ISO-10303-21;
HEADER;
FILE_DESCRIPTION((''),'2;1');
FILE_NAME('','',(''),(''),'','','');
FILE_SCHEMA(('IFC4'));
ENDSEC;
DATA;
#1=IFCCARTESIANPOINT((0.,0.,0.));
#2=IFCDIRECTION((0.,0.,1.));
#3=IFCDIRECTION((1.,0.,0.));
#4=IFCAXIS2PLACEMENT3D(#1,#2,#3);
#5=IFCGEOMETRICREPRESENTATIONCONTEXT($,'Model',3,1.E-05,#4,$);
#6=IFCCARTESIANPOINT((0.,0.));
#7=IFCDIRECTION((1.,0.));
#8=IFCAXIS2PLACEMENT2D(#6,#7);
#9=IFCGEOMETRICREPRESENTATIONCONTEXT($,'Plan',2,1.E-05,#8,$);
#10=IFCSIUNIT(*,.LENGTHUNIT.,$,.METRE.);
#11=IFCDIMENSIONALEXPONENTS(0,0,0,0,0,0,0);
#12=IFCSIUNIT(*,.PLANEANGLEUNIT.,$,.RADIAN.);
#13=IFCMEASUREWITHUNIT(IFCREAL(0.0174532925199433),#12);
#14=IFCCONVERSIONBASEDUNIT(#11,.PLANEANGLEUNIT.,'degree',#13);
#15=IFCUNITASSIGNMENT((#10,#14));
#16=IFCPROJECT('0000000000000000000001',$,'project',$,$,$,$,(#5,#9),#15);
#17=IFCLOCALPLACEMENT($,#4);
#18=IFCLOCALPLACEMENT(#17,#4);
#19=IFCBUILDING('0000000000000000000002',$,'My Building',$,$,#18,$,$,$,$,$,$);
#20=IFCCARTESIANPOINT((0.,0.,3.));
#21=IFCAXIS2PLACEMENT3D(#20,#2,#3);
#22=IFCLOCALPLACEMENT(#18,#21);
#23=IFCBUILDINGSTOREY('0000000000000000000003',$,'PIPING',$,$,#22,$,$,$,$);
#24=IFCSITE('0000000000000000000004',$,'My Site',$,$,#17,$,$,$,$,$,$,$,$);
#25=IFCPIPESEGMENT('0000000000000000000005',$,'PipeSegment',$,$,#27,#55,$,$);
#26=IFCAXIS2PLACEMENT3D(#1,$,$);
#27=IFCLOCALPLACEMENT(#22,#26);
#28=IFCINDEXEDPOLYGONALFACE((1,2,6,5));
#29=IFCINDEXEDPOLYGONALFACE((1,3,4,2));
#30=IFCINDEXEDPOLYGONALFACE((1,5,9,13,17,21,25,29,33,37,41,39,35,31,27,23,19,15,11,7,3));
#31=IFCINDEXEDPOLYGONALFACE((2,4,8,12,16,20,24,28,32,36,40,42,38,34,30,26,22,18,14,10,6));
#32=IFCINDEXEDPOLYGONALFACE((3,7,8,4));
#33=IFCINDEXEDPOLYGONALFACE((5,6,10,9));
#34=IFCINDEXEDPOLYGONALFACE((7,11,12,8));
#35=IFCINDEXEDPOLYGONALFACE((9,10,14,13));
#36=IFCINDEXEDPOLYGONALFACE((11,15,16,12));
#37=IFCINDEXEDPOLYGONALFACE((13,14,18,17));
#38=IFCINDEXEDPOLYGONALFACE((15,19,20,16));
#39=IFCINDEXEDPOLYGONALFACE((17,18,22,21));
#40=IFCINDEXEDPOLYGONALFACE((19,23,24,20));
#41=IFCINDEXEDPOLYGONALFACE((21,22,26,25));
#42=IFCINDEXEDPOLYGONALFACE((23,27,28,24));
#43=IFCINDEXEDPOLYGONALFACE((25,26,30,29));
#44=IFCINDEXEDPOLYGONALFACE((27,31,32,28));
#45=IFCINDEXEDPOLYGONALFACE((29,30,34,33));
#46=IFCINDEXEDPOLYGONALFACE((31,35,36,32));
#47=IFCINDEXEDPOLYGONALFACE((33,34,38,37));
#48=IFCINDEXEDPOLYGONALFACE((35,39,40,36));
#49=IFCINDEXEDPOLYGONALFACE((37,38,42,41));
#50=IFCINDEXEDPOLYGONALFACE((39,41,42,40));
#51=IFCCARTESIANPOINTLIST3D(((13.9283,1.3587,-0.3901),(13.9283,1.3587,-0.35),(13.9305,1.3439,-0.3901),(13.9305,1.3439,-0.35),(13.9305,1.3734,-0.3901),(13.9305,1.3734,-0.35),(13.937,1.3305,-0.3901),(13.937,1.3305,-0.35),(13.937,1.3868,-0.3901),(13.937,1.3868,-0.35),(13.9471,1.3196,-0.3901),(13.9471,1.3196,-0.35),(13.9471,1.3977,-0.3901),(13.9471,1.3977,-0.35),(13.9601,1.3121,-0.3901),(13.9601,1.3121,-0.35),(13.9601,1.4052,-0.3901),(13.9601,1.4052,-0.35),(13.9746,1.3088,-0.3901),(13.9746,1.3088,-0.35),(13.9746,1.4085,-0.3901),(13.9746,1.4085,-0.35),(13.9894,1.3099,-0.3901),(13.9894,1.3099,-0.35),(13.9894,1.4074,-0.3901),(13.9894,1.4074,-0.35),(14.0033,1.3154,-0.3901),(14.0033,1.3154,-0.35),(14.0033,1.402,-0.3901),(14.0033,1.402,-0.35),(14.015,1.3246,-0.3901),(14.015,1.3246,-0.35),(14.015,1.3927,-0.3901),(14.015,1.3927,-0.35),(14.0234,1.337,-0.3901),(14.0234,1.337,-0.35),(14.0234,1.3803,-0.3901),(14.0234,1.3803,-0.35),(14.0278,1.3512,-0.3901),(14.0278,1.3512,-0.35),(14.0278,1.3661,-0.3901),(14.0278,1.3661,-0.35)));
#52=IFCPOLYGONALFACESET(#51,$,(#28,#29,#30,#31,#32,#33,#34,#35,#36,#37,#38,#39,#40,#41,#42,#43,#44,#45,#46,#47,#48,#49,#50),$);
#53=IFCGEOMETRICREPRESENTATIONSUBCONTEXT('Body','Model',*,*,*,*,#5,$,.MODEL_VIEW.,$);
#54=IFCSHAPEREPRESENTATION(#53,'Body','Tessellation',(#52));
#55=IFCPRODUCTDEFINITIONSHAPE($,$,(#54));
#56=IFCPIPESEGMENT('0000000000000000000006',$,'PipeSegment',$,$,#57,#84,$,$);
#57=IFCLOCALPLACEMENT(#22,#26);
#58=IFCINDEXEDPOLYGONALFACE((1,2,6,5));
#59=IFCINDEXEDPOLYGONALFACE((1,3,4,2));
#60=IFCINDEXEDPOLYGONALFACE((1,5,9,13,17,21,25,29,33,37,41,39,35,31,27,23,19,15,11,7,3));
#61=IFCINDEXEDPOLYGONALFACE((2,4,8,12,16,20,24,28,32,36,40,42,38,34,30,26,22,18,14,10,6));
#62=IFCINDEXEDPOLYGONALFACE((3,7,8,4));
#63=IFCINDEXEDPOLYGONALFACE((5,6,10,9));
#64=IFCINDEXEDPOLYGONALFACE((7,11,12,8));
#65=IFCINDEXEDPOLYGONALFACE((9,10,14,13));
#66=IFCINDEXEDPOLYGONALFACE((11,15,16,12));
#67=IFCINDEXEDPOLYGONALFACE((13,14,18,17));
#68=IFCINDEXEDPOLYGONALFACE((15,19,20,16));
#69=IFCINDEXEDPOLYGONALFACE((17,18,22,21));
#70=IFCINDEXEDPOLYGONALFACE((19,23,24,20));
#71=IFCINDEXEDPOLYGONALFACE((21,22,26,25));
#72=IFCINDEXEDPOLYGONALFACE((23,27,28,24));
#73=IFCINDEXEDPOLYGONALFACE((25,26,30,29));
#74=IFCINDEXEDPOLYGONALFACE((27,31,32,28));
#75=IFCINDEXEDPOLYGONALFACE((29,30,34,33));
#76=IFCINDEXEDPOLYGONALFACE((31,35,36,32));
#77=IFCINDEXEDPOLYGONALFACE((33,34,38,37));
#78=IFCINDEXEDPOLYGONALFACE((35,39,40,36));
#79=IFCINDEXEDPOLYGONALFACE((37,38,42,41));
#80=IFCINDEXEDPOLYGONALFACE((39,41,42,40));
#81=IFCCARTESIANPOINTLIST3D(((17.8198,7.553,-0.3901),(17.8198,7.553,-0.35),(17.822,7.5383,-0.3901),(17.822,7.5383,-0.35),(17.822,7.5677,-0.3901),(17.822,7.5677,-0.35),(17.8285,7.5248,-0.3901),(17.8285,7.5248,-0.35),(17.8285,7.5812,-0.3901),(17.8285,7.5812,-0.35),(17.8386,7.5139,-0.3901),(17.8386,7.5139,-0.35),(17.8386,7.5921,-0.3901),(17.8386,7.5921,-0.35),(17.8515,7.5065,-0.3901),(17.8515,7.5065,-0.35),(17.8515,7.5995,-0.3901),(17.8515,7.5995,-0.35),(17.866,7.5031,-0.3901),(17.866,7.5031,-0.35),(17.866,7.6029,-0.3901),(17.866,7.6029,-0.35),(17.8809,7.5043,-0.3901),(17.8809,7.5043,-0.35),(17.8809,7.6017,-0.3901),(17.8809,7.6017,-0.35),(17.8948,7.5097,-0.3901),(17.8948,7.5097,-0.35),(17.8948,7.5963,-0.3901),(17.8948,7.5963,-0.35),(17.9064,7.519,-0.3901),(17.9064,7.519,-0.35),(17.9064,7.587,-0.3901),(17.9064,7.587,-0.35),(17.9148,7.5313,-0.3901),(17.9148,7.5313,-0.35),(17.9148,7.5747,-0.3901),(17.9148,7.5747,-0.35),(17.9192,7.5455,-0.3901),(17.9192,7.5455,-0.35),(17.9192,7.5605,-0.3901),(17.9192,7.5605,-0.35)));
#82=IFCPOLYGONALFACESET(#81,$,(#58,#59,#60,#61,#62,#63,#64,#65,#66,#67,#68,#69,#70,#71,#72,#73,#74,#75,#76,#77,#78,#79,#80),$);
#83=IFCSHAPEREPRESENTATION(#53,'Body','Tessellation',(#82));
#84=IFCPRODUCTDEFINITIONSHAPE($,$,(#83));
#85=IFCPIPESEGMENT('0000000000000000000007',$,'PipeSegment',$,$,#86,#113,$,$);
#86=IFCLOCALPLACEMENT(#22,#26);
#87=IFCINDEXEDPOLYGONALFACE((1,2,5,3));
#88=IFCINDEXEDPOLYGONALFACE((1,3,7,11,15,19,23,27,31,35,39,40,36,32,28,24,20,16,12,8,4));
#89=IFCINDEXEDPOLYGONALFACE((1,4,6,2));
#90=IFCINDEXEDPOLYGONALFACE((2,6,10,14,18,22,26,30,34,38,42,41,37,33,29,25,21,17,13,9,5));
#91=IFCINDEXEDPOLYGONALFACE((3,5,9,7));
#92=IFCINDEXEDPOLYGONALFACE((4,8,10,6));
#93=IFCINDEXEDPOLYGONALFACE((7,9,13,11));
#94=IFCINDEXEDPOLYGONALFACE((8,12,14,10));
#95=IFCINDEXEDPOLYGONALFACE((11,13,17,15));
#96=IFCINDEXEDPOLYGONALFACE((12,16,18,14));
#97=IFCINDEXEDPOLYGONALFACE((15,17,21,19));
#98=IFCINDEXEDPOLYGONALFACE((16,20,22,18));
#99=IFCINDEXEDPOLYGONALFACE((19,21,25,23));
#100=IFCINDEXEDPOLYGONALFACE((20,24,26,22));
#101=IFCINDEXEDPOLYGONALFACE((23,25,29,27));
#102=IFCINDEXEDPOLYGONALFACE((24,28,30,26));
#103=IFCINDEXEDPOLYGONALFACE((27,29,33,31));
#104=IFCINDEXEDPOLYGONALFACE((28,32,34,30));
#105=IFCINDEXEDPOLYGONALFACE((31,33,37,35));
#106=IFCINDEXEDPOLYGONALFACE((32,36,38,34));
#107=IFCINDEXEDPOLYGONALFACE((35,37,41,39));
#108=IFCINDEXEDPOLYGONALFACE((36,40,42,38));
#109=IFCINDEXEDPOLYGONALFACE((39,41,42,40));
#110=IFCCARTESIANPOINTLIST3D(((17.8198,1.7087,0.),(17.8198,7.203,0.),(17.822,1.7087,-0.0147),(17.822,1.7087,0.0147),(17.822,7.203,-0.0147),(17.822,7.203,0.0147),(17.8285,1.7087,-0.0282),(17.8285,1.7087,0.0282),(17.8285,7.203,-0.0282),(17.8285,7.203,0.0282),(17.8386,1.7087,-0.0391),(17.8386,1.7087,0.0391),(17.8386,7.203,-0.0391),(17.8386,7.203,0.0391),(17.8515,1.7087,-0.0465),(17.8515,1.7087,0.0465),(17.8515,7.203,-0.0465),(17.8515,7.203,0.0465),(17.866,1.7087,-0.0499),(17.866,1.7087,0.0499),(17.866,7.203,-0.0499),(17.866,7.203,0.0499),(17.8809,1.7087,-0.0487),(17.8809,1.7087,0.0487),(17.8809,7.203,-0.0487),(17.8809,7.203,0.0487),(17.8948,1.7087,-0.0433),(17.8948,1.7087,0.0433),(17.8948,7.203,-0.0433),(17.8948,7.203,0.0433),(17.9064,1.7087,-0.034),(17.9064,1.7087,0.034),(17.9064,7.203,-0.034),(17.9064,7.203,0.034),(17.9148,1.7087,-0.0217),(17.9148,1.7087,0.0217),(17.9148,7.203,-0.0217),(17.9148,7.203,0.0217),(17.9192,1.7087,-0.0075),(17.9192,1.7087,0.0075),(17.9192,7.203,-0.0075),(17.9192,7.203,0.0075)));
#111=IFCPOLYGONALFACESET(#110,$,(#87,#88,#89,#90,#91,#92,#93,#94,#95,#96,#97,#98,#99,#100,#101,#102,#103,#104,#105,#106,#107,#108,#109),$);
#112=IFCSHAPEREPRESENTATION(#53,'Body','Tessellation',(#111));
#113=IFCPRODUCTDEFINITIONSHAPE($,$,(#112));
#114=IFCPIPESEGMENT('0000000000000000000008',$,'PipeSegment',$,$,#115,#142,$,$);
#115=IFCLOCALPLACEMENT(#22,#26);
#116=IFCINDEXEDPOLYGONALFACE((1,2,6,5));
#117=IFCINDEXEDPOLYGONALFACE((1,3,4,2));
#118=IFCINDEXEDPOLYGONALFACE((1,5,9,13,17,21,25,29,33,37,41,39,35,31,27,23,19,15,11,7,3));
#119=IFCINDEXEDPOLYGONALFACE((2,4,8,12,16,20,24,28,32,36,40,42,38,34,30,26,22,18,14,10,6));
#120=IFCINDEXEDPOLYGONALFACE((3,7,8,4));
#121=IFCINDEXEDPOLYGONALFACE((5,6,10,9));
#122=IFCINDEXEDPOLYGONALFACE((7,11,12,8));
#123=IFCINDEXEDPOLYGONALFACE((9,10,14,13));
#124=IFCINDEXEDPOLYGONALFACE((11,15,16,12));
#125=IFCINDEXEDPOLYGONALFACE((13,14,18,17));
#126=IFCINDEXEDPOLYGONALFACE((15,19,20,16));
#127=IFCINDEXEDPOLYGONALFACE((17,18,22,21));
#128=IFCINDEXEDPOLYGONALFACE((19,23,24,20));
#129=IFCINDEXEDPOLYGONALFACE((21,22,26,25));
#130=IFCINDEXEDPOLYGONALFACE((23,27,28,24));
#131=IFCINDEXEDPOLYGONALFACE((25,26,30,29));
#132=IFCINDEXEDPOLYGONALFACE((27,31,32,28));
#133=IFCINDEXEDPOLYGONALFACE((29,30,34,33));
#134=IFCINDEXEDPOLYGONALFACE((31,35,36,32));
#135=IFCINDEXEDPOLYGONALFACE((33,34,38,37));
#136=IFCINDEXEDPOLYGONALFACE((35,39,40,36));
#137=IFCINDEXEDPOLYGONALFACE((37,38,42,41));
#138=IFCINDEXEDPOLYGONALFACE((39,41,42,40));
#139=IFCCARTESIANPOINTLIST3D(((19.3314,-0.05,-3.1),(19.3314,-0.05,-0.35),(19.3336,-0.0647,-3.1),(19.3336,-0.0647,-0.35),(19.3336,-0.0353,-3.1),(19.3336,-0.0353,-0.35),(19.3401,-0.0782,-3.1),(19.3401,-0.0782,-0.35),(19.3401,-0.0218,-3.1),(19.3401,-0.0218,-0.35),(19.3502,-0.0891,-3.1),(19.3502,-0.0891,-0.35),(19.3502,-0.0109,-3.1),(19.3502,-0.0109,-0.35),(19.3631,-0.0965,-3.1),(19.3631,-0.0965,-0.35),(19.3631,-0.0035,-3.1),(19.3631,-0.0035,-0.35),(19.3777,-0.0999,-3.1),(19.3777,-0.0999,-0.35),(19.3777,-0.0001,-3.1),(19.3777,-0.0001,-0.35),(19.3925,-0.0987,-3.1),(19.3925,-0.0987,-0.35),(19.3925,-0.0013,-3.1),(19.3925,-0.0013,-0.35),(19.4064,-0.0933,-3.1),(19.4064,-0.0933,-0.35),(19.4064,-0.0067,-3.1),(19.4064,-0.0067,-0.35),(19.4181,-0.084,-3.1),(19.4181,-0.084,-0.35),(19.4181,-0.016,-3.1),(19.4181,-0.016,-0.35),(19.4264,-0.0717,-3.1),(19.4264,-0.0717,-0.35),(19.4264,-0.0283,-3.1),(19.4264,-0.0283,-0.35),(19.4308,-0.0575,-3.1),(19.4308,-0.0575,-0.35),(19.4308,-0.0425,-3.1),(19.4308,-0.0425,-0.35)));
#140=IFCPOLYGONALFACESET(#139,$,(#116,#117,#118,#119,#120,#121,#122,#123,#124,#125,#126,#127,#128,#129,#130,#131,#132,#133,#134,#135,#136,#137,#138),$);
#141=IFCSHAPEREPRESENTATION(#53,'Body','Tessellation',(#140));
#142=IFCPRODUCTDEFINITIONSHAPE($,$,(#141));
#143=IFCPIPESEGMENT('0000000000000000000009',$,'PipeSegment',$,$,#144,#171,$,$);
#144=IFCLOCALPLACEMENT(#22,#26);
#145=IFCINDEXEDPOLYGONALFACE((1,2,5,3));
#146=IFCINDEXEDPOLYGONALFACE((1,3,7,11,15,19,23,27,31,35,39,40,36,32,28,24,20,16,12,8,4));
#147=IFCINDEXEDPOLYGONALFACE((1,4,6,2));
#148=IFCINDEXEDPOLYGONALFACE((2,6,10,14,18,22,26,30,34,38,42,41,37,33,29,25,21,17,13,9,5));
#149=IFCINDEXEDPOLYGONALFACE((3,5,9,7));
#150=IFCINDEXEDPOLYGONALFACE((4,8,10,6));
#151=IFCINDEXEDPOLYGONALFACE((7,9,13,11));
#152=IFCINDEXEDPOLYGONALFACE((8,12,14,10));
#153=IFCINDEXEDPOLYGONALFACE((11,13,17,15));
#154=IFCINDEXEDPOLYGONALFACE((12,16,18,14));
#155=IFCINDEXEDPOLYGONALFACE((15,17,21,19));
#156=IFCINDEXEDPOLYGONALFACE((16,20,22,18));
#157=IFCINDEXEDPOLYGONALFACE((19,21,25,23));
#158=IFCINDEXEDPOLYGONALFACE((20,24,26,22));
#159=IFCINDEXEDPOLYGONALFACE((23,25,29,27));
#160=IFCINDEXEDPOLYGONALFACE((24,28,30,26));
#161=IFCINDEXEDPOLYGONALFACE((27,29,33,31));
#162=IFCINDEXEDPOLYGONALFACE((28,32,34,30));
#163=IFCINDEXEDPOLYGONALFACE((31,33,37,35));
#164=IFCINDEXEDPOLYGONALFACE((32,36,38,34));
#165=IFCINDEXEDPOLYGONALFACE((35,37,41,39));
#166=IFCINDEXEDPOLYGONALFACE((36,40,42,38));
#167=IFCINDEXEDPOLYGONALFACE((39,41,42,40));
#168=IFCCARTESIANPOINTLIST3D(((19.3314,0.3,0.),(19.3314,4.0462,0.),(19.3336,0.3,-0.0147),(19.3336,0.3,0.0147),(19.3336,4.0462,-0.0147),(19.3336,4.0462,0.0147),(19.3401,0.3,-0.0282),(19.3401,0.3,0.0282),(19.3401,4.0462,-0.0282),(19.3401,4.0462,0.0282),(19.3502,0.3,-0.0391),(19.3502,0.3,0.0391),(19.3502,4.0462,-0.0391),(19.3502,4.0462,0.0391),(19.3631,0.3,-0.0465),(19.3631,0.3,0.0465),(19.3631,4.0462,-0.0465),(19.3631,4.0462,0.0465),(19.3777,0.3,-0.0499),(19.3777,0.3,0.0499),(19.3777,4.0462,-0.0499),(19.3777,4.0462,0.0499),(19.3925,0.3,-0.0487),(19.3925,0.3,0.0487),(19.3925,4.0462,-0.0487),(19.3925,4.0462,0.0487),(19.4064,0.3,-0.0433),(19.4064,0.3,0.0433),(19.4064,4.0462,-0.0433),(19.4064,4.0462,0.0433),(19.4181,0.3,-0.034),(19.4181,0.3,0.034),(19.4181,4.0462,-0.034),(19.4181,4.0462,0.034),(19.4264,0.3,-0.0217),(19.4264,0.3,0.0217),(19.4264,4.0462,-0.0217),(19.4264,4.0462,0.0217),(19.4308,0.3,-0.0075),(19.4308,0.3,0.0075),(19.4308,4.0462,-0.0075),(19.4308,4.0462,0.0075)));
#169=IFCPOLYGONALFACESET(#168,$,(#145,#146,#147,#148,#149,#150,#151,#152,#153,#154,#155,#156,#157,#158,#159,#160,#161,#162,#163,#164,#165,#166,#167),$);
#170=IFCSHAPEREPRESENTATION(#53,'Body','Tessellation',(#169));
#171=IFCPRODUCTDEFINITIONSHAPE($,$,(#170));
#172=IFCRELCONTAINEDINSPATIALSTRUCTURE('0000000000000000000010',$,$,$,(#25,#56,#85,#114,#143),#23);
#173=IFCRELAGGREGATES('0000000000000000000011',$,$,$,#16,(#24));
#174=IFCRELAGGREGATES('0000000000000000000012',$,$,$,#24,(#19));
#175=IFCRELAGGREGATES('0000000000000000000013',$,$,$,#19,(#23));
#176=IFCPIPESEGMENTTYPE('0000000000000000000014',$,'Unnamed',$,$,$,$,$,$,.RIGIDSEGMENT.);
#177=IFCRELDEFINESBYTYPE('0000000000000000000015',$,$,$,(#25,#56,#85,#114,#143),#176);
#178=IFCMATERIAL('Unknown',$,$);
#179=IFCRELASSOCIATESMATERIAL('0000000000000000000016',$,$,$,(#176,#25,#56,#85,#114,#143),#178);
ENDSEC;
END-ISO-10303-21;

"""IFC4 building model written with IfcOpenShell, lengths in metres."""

from ifc_helpers import new_model, entity, si_unit, converted_unit, frame, origin_with_axes, origin_2d_with_axis, place, context, subcontext, project, spatial, circle, extrude, material, material_profile, profile_set, profile_usage, type_object, element, save


model = new_model("IFC4")

# Units and contexts
model_context = context("Model", 3, precision=1e-05, world=origin_with_axes())
plan_context = context("Plan", 2, precision=1e-05, world=origin_2d_with_axis())
body_context = subcontext(model_context, "Body", "Model", "MODEL_VIEW")
ifc_project = project(units=[si_unit("LENGTHUNIT", "METRE"), converted_unit("PLANEANGLEUNIT", "degree", entity("IfcReal", 0.0174532925199433), si_unit("PLANEANGLEUNIT", "RADIAN"), dimensions=[0, 0, 0, 0, 0, 0, 0])], contexts=[model_context, plan_context])

# Site, building, storey
site_placement = place(None, origin_with_axes())
site = spatial("IfcSite", under=ifc_project, at=site_placement, Name="My Site")
building_placement = place(site_placement, origin_with_axes())
building = spatial("IfcBuilding", under=site, at=building_placement, Name="My Building")
storey_placement = place(building_placement, frame((0.0, 0.0, 3.0), z_axis=(0.0, 0.0, 1.0), x_axis=(1.0, 0.0, 0.0)))
storey = spatial("IfcBuildingStorey", under=building, at=storey_placement, Name="PIPING")

# Pipe segments
ifc_material = material(Name="Unknown")
ifc_material_profile = material_profile(ifc_material, circle(Radius=0.05))
ifc_profile_set = profile_set([ifc_material_profile])
pipe_segment_type = type_object("IfcPipeSegmentType", Name="Unnamed", PredefinedType="RIGIDSEGMENT", material=ifc_profile_set)
ifc_profile_usage_1 = profile_usage(ifc_profile_set, cardinal=5)
pipe_segment_1_placement = place(storey_placement, frame((13.9783, 1.3587, -0.35), z_axis=(0.0, 0.0, -1.0), x_axis=(-1.0, 0.0, 0.0)))
element("IfcPipeSegment", 1, at=pipe_segment_1_placement, inside=storey, type_object=pipe_segment_type, material=ifc_profile_usage_1, Name="PipeSegment", context=body_context, shape_type="SweptSolid", body=[
    extrude(circle(Radius=0.05), origin_with_axes(), (0.0, 0.0, 1.0), 0.0401),
])
ifc_profile_usage_2 = profile_usage(ifc_profile_set, cardinal=5)
pipe_segment_2_placement = place(storey_placement, frame((17.8698, 7.553, -0.35), z_axis=(0.0, 0.0, -1.0), x_axis=(-1.0, 0.0, 0.0)))
element("IfcPipeSegment", 2, at=pipe_segment_2_placement, inside=storey, type_object=pipe_segment_type, material=ifc_profile_usage_2, Name="PipeSegment", context=body_context, shape_type="SweptSolid", body=[
    extrude(circle(Radius=0.05), origin_with_axes(), (0.0, 0.0, 1.0), 0.0401),
])
ifc_profile_usage_3 = profile_usage(ifc_profile_set, cardinal=5)
pipe_segment_3_placement = place(storey_placement, frame((17.8698, 1.7087, 0.0), z_axis=(0.0, 1.0, 0.0), x_axis=(-1.0, 0.0, 0.0)))
element("IfcPipeSegment", 3, at=pipe_segment_3_placement, inside=storey, type_object=pipe_segment_type, material=ifc_profile_usage_3, Name="PipeSegment", context=body_context, shape_type="SweptSolid", body=[
    extrude(circle(Radius=0.05), origin_with_axes(), (0.0, 0.0, 1.0), 5.4943),
])
ifc_profile_usage_4 = profile_usage(ifc_profile_set, cardinal=5)
pipe_segment_4_placement = place(storey_placement, frame((19.3814, -0.05, -0.35), z_axis=(0.0, 0.0, -1.0), x_axis=(-1.0, 0.0, 0.0)))
element("IfcPipeSegment", 4, at=pipe_segment_4_placement, inside=storey, type_object=pipe_segment_type, material=ifc_profile_usage_4, Name="PipeSegment", context=body_context, shape_type="SweptSolid", body=[
    extrude(circle(Radius=0.05), origin_with_axes(), (0.0, 0.0, 1.0), 2.75),
])
ifc_profile_usage_5 = profile_usage(ifc_profile_set, cardinal=5)
pipe_segment_5_placement = place(storey_placement, frame((19.3814, 0.3, 0.0), z_axis=(0.0, 1.0, 0.0), x_axis=(-1.0, 0.0, 0.0)))
element("IfcPipeSegment", 5, at=pipe_segment_5_placement, inside=storey, type_object=pipe_segment_type, material=ifc_profile_usage_5, Name="PipeSegment", context=body_context, shape_type="SweptSolid", body=[
    extrude(circle(Radius=0.05), origin_with_axes(), (0.0, 0.0, 1.0), 3.7462),
])

save(model, "model.ifc")
